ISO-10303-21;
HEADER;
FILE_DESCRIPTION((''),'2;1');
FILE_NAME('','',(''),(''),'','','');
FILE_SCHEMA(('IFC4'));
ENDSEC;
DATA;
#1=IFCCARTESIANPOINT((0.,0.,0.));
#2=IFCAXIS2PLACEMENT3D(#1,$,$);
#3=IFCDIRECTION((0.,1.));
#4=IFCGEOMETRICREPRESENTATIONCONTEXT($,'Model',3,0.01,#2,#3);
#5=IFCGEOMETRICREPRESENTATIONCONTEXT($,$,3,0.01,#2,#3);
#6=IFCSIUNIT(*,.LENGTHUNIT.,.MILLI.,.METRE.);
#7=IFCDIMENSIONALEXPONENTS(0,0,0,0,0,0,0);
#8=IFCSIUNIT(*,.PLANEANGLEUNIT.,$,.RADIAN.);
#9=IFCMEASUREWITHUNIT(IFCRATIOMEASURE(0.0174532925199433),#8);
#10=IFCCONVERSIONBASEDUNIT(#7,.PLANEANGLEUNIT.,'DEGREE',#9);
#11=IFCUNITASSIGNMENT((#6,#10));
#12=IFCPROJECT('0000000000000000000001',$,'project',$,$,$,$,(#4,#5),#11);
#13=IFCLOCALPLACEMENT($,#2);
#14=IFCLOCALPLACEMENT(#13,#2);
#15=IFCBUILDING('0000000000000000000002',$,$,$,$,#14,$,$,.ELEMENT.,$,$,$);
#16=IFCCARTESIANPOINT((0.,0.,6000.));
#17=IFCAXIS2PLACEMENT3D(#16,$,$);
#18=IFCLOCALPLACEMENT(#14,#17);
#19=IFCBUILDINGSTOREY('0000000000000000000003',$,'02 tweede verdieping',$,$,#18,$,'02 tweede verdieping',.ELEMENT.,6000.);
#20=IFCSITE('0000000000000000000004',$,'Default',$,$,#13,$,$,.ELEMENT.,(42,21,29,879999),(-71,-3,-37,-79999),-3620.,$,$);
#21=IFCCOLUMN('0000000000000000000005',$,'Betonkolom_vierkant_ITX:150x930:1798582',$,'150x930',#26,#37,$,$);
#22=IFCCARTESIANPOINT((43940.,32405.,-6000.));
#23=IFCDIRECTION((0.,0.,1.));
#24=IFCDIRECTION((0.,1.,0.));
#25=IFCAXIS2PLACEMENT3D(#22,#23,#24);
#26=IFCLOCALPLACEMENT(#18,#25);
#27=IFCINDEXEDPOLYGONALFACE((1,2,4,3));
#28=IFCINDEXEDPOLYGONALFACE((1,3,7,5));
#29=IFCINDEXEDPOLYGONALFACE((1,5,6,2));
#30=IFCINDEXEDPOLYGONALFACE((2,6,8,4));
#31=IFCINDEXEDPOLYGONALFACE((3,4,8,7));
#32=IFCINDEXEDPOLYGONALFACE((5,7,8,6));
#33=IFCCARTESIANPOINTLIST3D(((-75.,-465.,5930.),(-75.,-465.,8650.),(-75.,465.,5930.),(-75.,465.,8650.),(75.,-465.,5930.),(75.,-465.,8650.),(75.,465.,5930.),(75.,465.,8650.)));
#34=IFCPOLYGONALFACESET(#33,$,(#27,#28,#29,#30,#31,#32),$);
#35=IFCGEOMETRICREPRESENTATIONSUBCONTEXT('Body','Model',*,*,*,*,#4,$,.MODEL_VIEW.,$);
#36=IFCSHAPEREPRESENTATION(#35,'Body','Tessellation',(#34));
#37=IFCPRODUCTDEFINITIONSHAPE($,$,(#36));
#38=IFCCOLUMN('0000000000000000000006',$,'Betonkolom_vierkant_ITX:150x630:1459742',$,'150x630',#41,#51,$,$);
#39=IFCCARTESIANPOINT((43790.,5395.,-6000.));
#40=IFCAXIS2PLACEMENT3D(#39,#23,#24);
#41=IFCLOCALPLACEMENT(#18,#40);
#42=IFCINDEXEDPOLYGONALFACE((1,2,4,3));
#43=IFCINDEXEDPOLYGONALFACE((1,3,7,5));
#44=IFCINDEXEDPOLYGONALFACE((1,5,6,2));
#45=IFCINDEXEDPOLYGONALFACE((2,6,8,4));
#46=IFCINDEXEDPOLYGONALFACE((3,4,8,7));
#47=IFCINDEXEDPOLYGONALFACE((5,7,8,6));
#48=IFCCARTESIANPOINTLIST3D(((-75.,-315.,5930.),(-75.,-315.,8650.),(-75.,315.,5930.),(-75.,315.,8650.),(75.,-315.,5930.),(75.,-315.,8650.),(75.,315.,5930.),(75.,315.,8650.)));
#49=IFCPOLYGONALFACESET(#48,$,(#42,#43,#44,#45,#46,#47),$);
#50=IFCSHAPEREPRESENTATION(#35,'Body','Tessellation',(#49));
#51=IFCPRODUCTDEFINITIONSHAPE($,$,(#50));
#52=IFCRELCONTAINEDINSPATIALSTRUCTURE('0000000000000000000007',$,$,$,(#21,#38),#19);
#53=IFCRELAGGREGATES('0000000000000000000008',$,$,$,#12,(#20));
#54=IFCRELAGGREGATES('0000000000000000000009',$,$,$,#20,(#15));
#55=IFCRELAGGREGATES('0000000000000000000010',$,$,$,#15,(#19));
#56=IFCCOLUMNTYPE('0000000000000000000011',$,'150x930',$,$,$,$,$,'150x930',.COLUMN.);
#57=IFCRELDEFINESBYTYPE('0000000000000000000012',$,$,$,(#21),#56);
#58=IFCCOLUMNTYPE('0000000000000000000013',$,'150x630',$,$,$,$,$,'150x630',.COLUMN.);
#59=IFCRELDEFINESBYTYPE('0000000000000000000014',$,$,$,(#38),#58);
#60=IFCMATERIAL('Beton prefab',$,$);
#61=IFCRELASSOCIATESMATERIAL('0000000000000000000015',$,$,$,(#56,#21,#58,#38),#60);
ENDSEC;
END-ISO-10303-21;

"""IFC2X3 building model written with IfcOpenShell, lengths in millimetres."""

from ifc_helpers import new_model, entity, si_unit, converted_unit, direction, frame, origin, origin_2d_with_axis, place, context, subcontext, project, spatial, rectangle, extrude, source, transform, mapped, material, type_object, type_shapes, element, save


model = new_model("IFC2X3")

# Units and contexts
model_context = context("Model", 3, precision=0.01, world=origin(), true_north=direction((0.0, 1.0)))
context_of_model = context(None, 3, precision=0.01, world=origin(), true_north=direction((0.0, 1.0)))
body_context = subcontext(model_context, "Body", "Model", "MODEL_VIEW")
ifc_project = project(units=[si_unit("LENGTHUNIT", "METRE", prefix="MILLI"), converted_unit("PLANEANGLEUNIT", "DEGREE", entity("IfcRatioMeasure", 0.0174532925199433), si_unit("PLANEANGLEUNIT", "RADIAN"), dimensions=[0, 0, 0, 0, 0, 0, 0])], contexts=[model_context, context_of_model])

# Site, building, storey
site_placement = place(None, origin())
site = spatial("IfcSite", under=ifc_project, at=site_placement, Name="Default", CompositionType="ELEMENT", RefLatitude=(42, 21, 29, 879999), RefLongitude=(-71, -3, -37, -79999), RefElevation=-3620.0)
building_placement = place(site_placement, origin())
building = spatial("IfcBuilding", under=site, at=building_placement, CompositionType="ELEMENT")
storey_placement = place(building_placement, frame((0.0, 0.0, 6000.0)))
storey = spatial("IfcBuildingStorey", under=building, at=storey_placement, Name="02 tweede verdieping", LongName="02 tweede verdieping", CompositionType="ELEMENT", Elevation=6000.0)

# Columns
ifc_material_1 = material(Name="Beton prefab")
column_type_1 = type_object("IfcColumnType", Name="150x930", ElementType="150x930", PredefinedType="COLUMN", material=ifc_material_1)
shared_shape_1 = source(origin(), body_context, "Body", "SweptSolid", [
    extrude(rectangle(XDim=930.0, YDim=150.0, at=origin_2d_with_axis()), frame((0.0, 0.0, 5930.0), z_axis=(0.0, 0.0, 1.0), x_axis=(0.0, -1.0, 0.0)), (0.0, 0.0, 1.0), 2720.0),
])
type_shapes(column_type_1, [shared_shape_1])
column_1_placement = place(storey_placement, frame((43940.0, 32405.0, -6000.0), z_axis=(0.0, 0.0, 1.0), x_axis=(0.0, 1.0, 0.0)))
element("IfcColumn", 1, at=column_1_placement, inside=storey, type_object=column_type_1, material=ifc_material_1, Name="Betonkolom_vierkant_ITX:150x930:1798582", ObjectType="150x930", context=body_context, shape_type="MappedRepresentation", body=[
    mapped(shared_shape_1, transform((0.0, 0.0, 0.0), scale=1.0)),
])
column_type_2 = type_object("IfcColumnType", Name="150x630", ElementType="150x630", PredefinedType="COLUMN", material=ifc_material_1)
shared_shape_2 = source(origin(), body_context, "Body", "SweptSolid", [
    extrude(rectangle(XDim=630.0, YDim=150.0, at=origin_2d_with_axis()), frame((0.0, 0.0, 5930.0), z_axis=(0.0, 0.0, 1.0), x_axis=(0.0, -1.0, 0.0)), (0.0, 0.0, 1.0), 2720.0),
])
type_shapes(column_type_2, [shared_shape_2])
column_2_placement = place(storey_placement, frame((43790.0, 5395.0, -6000.0), z_axis=(0.0, 0.0, 1.0), x_axis=(0.0, 1.0, 0.0)))
element("IfcColumn", 2, at=column_2_placement, inside=storey, type_object=column_type_2, material=ifc_material_1, Name="Betonkolom_vierkant_ITX:150x630:1459742", ObjectType="150x630", context=body_context, shape_type="MappedRepresentation", body=[
    mapped(shared_shape_2, transform((0.0, 0.0, 0.0), scale=1.0)),
])

save(model, "model.ifc")
